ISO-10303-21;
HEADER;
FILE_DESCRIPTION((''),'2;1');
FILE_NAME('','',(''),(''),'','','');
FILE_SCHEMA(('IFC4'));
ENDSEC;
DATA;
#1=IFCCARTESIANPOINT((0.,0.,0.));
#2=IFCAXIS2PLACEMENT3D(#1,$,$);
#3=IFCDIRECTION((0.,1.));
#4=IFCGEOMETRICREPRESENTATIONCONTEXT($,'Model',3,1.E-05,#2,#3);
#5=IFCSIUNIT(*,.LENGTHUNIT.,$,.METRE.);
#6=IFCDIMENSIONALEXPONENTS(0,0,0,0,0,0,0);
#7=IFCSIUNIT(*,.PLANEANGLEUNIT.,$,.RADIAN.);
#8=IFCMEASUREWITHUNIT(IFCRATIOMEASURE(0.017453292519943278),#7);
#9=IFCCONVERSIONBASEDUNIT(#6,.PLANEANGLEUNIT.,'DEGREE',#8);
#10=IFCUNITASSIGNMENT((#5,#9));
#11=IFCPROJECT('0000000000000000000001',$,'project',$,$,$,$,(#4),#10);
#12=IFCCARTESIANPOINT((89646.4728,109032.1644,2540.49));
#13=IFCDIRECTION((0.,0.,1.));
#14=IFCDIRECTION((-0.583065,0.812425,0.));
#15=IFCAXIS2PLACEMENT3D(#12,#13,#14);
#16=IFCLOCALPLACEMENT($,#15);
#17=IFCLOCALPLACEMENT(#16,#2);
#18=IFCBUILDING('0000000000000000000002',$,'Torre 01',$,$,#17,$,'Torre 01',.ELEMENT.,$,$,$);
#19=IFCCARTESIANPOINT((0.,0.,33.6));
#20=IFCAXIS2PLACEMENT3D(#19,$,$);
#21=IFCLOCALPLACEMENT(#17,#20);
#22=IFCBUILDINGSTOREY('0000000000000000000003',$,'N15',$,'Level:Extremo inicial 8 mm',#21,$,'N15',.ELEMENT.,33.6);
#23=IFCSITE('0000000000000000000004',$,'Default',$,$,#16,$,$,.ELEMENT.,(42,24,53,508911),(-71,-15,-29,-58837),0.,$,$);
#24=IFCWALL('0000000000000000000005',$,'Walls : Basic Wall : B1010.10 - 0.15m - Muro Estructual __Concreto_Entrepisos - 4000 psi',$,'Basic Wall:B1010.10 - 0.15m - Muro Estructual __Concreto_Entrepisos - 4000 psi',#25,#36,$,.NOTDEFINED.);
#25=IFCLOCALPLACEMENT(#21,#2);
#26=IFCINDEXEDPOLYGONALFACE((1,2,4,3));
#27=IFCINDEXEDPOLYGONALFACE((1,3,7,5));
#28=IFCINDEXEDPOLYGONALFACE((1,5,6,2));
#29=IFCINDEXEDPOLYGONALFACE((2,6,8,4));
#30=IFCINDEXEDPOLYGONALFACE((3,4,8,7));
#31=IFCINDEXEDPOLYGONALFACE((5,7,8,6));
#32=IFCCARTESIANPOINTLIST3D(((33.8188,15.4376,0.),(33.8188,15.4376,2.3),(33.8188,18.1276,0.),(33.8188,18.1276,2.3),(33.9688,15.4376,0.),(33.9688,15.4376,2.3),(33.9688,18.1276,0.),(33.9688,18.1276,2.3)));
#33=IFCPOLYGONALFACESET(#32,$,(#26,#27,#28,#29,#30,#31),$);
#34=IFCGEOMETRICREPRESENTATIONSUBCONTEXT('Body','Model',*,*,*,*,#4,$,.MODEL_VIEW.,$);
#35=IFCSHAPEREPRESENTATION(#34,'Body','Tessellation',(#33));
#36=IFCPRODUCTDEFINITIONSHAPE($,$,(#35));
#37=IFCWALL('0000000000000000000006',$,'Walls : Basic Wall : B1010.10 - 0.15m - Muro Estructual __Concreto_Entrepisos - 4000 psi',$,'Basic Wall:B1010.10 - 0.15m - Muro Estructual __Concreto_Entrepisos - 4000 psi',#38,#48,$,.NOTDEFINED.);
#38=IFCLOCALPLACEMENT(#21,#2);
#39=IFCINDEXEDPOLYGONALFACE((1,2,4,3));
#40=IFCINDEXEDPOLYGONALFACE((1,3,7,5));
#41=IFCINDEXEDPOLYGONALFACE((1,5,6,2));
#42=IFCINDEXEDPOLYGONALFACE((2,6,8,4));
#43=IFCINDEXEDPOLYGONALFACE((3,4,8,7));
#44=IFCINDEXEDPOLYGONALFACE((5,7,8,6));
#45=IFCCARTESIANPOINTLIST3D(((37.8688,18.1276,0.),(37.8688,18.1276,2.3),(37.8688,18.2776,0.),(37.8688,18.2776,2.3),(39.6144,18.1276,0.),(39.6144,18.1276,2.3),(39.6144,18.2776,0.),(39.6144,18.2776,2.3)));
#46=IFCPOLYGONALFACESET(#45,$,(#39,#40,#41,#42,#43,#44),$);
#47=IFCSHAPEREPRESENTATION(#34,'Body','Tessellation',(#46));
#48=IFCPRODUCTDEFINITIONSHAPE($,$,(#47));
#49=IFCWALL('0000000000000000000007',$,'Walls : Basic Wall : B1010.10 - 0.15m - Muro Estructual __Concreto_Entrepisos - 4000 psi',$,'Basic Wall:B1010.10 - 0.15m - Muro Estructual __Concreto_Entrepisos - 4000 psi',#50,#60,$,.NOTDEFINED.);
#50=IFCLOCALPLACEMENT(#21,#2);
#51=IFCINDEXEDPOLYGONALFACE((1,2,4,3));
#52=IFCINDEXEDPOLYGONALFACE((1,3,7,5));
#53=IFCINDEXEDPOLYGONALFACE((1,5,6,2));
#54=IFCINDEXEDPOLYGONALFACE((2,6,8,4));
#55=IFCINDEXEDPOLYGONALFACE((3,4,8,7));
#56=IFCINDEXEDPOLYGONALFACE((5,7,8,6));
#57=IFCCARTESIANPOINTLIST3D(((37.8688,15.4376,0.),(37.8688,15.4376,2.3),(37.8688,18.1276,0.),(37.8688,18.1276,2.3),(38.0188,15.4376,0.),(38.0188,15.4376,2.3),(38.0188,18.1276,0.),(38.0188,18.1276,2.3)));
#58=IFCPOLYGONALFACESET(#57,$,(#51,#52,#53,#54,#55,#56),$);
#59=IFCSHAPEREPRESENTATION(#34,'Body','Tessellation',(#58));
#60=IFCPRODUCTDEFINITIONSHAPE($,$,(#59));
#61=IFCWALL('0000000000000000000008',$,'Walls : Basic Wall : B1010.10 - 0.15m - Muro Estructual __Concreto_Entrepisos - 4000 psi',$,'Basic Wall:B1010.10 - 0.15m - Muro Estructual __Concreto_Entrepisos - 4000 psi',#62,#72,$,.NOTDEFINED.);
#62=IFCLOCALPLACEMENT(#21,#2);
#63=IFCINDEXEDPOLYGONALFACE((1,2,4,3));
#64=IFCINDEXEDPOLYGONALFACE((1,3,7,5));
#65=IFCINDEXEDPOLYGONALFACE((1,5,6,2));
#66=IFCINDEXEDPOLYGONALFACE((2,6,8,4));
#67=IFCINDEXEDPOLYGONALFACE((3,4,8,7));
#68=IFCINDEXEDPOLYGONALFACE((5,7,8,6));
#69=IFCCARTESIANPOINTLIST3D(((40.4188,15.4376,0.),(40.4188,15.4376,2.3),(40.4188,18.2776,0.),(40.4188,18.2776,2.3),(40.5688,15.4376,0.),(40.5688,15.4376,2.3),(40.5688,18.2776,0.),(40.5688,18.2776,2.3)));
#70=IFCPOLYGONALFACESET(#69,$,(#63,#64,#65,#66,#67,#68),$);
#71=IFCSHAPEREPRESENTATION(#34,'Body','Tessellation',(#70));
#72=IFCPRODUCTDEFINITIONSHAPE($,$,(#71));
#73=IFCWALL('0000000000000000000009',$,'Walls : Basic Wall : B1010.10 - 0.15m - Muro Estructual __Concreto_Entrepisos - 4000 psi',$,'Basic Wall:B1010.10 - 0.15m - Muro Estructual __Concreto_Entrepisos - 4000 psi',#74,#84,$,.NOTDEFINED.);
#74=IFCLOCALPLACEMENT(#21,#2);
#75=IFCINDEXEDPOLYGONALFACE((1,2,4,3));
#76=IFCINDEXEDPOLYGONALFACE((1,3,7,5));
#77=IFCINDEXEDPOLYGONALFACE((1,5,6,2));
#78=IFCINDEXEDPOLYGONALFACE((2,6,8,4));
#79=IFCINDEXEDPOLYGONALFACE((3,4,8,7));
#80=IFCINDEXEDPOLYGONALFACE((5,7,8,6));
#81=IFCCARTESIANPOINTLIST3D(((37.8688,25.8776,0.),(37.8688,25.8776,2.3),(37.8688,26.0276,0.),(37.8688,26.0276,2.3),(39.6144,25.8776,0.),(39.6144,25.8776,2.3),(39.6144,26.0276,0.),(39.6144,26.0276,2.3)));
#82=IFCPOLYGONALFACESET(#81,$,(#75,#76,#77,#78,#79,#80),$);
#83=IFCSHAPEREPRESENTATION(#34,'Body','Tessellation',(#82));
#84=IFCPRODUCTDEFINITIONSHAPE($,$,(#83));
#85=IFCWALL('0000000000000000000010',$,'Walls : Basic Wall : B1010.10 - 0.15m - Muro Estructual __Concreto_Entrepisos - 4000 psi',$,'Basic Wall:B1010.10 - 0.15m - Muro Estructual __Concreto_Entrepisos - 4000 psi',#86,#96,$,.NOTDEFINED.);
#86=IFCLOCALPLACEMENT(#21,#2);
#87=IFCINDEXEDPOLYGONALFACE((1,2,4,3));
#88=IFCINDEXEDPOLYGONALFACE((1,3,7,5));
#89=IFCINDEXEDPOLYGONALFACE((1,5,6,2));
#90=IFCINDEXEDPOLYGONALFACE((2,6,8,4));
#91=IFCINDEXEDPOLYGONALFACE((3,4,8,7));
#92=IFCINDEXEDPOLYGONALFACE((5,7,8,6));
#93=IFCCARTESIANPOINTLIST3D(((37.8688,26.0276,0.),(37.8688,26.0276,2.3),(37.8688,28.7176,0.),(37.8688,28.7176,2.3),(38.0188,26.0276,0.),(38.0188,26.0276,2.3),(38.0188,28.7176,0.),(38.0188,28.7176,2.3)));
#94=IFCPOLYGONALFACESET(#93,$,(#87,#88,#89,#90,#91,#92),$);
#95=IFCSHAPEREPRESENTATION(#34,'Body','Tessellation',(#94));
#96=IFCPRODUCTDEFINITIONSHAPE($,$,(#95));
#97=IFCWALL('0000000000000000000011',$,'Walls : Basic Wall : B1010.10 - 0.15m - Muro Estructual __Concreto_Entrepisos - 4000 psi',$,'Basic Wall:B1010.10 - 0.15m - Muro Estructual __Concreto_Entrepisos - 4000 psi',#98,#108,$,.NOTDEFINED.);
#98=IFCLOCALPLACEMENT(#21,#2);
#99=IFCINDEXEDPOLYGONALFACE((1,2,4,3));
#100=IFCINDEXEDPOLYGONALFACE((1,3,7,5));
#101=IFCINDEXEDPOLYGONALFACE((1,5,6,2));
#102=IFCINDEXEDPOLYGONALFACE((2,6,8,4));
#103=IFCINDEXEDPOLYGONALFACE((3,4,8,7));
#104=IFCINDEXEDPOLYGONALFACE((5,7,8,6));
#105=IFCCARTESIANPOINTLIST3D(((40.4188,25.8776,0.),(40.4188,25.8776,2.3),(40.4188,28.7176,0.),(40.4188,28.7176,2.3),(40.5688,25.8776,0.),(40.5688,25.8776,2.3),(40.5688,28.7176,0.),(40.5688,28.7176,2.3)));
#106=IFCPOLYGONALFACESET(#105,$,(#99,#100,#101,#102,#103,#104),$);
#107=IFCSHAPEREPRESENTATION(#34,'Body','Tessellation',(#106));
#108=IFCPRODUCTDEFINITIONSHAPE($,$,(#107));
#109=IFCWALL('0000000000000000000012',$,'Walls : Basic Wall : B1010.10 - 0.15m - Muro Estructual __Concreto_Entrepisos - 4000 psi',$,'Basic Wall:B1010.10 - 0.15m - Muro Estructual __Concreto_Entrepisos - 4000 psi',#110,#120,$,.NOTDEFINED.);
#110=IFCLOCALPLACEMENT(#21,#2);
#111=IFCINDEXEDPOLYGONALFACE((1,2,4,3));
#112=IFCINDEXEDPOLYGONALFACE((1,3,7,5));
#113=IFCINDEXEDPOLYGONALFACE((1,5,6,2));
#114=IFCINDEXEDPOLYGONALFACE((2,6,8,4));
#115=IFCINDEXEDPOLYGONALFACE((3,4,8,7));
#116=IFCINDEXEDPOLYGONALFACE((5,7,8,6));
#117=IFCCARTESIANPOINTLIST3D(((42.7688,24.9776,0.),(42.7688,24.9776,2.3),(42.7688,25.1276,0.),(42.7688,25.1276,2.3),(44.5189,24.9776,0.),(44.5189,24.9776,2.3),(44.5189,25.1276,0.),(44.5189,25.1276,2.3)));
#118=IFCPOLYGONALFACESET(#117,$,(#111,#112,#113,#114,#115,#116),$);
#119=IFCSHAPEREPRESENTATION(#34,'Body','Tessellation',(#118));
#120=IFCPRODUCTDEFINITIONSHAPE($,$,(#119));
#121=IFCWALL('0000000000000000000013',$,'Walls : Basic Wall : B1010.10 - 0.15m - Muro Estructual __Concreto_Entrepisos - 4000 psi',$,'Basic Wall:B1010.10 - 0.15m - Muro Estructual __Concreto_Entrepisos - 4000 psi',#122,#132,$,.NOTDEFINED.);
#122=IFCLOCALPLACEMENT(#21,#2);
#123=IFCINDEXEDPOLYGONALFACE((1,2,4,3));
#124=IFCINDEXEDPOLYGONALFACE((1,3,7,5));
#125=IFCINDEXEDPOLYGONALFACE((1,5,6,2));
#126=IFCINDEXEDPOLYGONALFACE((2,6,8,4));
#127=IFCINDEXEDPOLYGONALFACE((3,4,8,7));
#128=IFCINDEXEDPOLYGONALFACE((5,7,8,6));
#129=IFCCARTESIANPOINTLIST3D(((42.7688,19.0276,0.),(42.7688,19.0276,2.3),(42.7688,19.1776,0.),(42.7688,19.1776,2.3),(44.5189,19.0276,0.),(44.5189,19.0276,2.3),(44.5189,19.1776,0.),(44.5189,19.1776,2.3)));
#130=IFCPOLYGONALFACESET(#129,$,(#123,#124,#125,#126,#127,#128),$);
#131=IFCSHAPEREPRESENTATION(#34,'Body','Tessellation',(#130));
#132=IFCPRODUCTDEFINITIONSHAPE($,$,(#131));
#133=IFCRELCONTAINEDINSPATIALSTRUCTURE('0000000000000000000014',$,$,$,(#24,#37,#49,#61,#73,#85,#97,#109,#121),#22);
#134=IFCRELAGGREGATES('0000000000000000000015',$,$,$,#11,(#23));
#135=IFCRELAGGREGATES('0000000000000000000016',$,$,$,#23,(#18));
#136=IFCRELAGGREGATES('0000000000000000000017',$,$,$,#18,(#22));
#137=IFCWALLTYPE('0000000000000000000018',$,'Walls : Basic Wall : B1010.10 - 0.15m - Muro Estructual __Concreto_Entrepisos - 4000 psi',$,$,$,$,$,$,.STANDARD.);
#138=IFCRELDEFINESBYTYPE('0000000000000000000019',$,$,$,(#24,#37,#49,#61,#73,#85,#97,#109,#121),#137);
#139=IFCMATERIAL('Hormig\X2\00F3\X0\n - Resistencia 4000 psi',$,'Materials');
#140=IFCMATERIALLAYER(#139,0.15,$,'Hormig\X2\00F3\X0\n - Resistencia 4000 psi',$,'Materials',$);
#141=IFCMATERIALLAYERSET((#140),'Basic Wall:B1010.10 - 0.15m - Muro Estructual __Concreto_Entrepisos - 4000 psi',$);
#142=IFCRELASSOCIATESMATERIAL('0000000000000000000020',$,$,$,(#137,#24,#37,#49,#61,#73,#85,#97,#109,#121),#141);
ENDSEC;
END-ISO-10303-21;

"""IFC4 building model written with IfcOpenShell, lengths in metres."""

from ifc_helpers import new_model, entity, si_unit, converted_unit, direction, frame, frame_2d, origin, place, context, subcontext, project, spatial, rectangle, extrude, material, layer, layer_set, layer_usage, type_object, element, save


model = new_model("IFC4")

# Units and contexts
model_context = context("Model", 3, precision=1e-05, world=origin(), true_north=direction((0.0, 1.0)))
body_context = subcontext(model_context, "Body", "Model", "MODEL_VIEW")
ifc_project = project(units=[si_unit("LENGTHUNIT", "METRE"), converted_unit("PLANEANGLEUNIT", "DEGREE", entity("IfcRatioMeasure", 0.017453292519943278), si_unit("PLANEANGLEUNIT", "RADIAN"), dimensions=[0, 0, 0, 0, 0, 0, 0])], contexts=[model_context])

# Site, building, storey
site_placement = place(None, frame((89646.4728, 109032.1644, 2540.49), z_axis=(0.0, 0.0, 1.0), x_axis=(-0.583065, 0.812425, 0.0)))
site = spatial("IfcSite", under=ifc_project, at=site_placement, Name="Default", CompositionType="ELEMENT", RefLatitude=(42, 24, 53, 508911), RefLongitude=(-71, -15, -29, -58837), RefElevation=0.0)
building_placement = place(site_placement, origin())
building = spatial("IfcBuilding", under=site, at=building_placement, Name="Torre 01", LongName="Torre 01", CompositionType="ELEMENT")
storey_placement = place(building_placement, frame((0.0, 0.0, 33.6)))
storey = spatial("IfcBuildingStorey", under=building, at=storey_placement, Name="N15", ObjectType="Level:Extremo inicial 8 mm", LongName="N15", CompositionType="ELEMENT", Elevation=33.6)

# Walls
ifc_material = material(Name="Hormigón - Resistencia 4000 psi", Category="Materials")
ifc_layer_1 = layer(ifc_material, 0.15, Name="Hormigón - Resistencia 4000 psi", Category="Materials")
ifc_layer_set_1 = layer_set([ifc_layer_1], Name="Basic Wall:B1010.10 - 0.15m - Muro Estructual __Concreto_Entrepisos - 4000 psi")
wall_type_1 = type_object("IfcWallType", Name="Walls : Basic Wall : B1010.10 - 0.15m - Muro Estructual __Concreto_Entrepisos - 4000 psi", PredefinedType="STANDARD", material=ifc_layer_set_1)
ifc_layer_usage_1 = layer_usage(ifc_layer_set_1, "AXIS2", "NEGATIVE", 0.075)
wall_1_placement = place(storey_placement, frame((33.8938, 18.1276, 0.0), z_axis=(0.0, 0.0, 1.0), x_axis=(0.0, -1.0, 0.0)))
element("IfcWall", 1, at=wall_1_placement, inside=storey, type_object=wall_type_1, material=ifc_layer_usage_1, Name="Walls : Basic Wall : B1010.10 - 0.15m - Muro Estructual __Concreto_Entrepisos - 4000 psi", ObjectType="Basic Wall:B1010.10 - 0.15m - Muro Estructual __Concreto_Entrepisos - 4000 psi", PredefinedType="NOTDEFINED", context=body_context, shape_type="SweptSolid", body=[
    extrude(rectangle(XDim=2.69, YDim=0.15, at=frame_2d((1.345, 0.0), x_axis=(-1.0, 0.0))), origin(), (0.0, 0.0, 1.0), 2.3),
])
ifc_layer_usage_2 = layer_usage(ifc_layer_set_1, "AXIS2", "NEGATIVE", 0.075)
wall_2_placement = place(storey_placement, frame((39.6144, 18.2026, 0.0), z_axis=(0.0, 0.0, 1.0), x_axis=(-1.0, 0.0, 0.0)))
element("IfcWall", 2, at=wall_2_placement, inside=storey, type_object=wall_type_1, material=ifc_layer_usage_2, Name="Walls : Basic Wall : B1010.10 - 0.15m - Muro Estructual __Concreto_Entrepisos - 4000 psi", ObjectType="Basic Wall:B1010.10 - 0.15m - Muro Estructual __Concreto_Entrepisos - 4000 psi", PredefinedType="NOTDEFINED", context=body_context, shape_type="SweptSolid", body=[
    extrude(rectangle(XDim=1.7455, YDim=0.15, at=frame_2d((0.8728, 0.0), x_axis=(-1.0, 0.0))), origin(), (0.0, 0.0, 1.0), 2.3),
])
ifc_layer_usage_3 = layer_usage(ifc_layer_set_1, "AXIS2", "NEGATIVE", 0.075)
wall_3_placement = place(storey_placement, frame((37.9438, 18.1276, 0.0), z_axis=(0.0, 0.0, 1.0), x_axis=(0.0, -1.0, 0.0)))
element("IfcWall", 3, at=wall_3_placement, inside=storey, type_object=wall_type_1, material=ifc_layer_usage_3, Name="Walls : Basic Wall : B1010.10 - 0.15m - Muro Estructual __Concreto_Entrepisos - 4000 psi", ObjectType="Basic Wall:B1010.10 - 0.15m - Muro Estructual __Concreto_Entrepisos - 4000 psi", PredefinedType="NOTDEFINED", context=body_context, shape_type="SweptSolid", body=[
    extrude(rectangle(XDim=2.69, YDim=0.15, at=frame_2d((1.345, 0.0), x_axis=(-1.0, 0.0))), origin(), (0.0, 0.0, 1.0), 2.3),
])
ifc_layer_usage_4 = layer_usage(ifc_layer_set_1, "AXIS2", "NEGATIVE", 0.075)
wall_4_placement = place(storey_placement, frame((40.4938, 18.2776, 0.0), z_axis=(0.0, 0.0, 1.0), x_axis=(0.0, -1.0, 0.0)))
element("IfcWall", 4, at=wall_4_placement, inside=storey, type_object=wall_type_1, material=ifc_layer_usage_4, Name="Walls : Basic Wall : B1010.10 - 0.15m - Muro Estructual __Concreto_Entrepisos - 4000 psi", ObjectType="Basic Wall:B1010.10 - 0.15m - Muro Estructual __Concreto_Entrepisos - 4000 psi", PredefinedType="NOTDEFINED", context=body_context, shape_type="SweptSolid", body=[
    extrude(rectangle(XDim=2.84, YDim=0.15, at=frame_2d((1.42, 0.0), x_axis=(-1.0, 0.0))), origin(), (0.0, 0.0, 1.0), 2.3),
])
ifc_layer_usage_5 = layer_usage(ifc_layer_set_1, "AXIS2", "POSITIVE", -0.075)
wall_5_placement = place(storey_placement, frame((39.6144, 25.9526, 0.0), z_axis=(0.0, 0.0, 1.0), x_axis=(-1.0, 0.0, 0.0)))
element("IfcWall", 5, at=wall_5_placement, inside=storey, type_object=wall_type_1, material=ifc_layer_usage_5, Name="Walls : Basic Wall : B1010.10 - 0.15m - Muro Estructual __Concreto_Entrepisos - 4000 psi", ObjectType="Basic Wall:B1010.10 - 0.15m - Muro Estructual __Concreto_Entrepisos - 4000 psi", PredefinedType="NOTDEFINED", context=body_context, shape_type="SweptSolid", body=[
    extrude(rectangle(XDim=1.7455, YDim=0.15, at=frame_2d((0.8728, 0.0), x_axis=(-1.0, 0.0))), origin(), (0.0, 0.0, 1.0), 2.3),
])
ifc_layer_usage_6 = layer_usage(ifc_layer_set_1, "AXIS2", "POSITIVE", -0.075)
wall_6_placement = place(storey_placement, frame((37.9438, 26.0276, 0.0), z_axis=(0.0, 0.0, 1.0), x_axis=(0.0, 1.0, 0.0)))
element("IfcWall", 6, at=wall_6_placement, inside=storey, type_object=wall_type_1, material=ifc_layer_usage_6, Name="Walls : Basic Wall : B1010.10 - 0.15m - Muro Estructual __Concreto_Entrepisos - 4000 psi", ObjectType="Basic Wall:B1010.10 - 0.15m - Muro Estructual __Concreto_Entrepisos - 4000 psi", PredefinedType="NOTDEFINED", context=body_context, shape_type="SweptSolid", body=[
    extrude(rectangle(XDim=2.69, YDim=0.15, at=frame_2d((1.345, 0.0), x_axis=(-1.0, 0.0))), origin(), (0.0, 0.0, 1.0), 2.3),
])
ifc_layer_usage_7 = layer_usage(ifc_layer_set_1, "AXIS2", "POSITIVE", -0.075)
wall_7_placement = place(storey_placement, frame((40.4938, 25.8776, 0.0), z_axis=(0.0, 0.0, 1.0), x_axis=(0.0, 1.0, 0.0)))
element("IfcWall", 7, at=wall_7_placement, inside=storey, type_object=wall_type_1, material=ifc_layer_usage_7, Name="Walls : Basic Wall : B1010.10 - 0.15m - Muro Estructual __Concreto_Entrepisos - 4000 psi", ObjectType="Basic Wall:B1010.10 - 0.15m - Muro Estructual __Concreto_Entrepisos - 4000 psi", PredefinedType="NOTDEFINED", context=body_context, shape_type="SweptSolid", body=[
    extrude(rectangle(XDim=2.84, YDim=0.15, at=frame_2d((1.42, 0.0), x_axis=(-1.0, 0.0))), origin(), (0.0, 0.0, 1.0), 2.3),
])
ifc_layer_usage_8 = layer_usage(ifc_layer_set_1, "AXIS2", "NEGATIVE", 0.075)
wall_8_placement = place(storey_placement, frame((42.7688, 25.0526, 0.0)))
element("IfcWall", 8, at=wall_8_placement, inside=storey, type_object=wall_type_1, material=ifc_layer_usage_8, Name="Walls : Basic Wall : B1010.10 - 0.15m - Muro Estructual __Concreto_Entrepisos - 4000 psi", ObjectType="Basic Wall:B1010.10 - 0.15m - Muro Estructual __Concreto_Entrepisos - 4000 psi", PredefinedType="NOTDEFINED", context=body_context, shape_type="SweptSolid", body=[
    extrude(rectangle(XDim=1.75, YDim=0.15, at=frame_2d((0.875, 0.0), x_axis=(-1.0, 0.0))), origin(), (0.0, 0.0, 1.0), 2.3),
])
ifc_layer_usage_9 = layer_usage(ifc_layer_set_1, "AXIS2", "POSITIVE", -0.075)
wall_9_placement = place(storey_placement, frame((42.7688, 19.1026, 0.0)))
element("IfcWall", 9, at=wall_9_placement, inside=storey, type_object=wall_type_1, material=ifc_layer_usage_9, Name="Walls : Basic Wall : B1010.10 - 0.15m - Muro Estructual __Concreto_Entrepisos - 4000 psi", ObjectType="Basic Wall:B1010.10 - 0.15m - Muro Estructual __Concreto_Entrepisos - 4000 psi", PredefinedType="NOTDEFINED", context=body_context, shape_type="SweptSolid", body=[
    extrude(rectangle(XDim=1.75, YDim=0.15, at=frame_2d((0.875, 0.0), x_axis=(-1.0, 0.0))), origin(), (0.0, 0.0, 1.0), 2.3),
])

save(model, "model.ifc")
